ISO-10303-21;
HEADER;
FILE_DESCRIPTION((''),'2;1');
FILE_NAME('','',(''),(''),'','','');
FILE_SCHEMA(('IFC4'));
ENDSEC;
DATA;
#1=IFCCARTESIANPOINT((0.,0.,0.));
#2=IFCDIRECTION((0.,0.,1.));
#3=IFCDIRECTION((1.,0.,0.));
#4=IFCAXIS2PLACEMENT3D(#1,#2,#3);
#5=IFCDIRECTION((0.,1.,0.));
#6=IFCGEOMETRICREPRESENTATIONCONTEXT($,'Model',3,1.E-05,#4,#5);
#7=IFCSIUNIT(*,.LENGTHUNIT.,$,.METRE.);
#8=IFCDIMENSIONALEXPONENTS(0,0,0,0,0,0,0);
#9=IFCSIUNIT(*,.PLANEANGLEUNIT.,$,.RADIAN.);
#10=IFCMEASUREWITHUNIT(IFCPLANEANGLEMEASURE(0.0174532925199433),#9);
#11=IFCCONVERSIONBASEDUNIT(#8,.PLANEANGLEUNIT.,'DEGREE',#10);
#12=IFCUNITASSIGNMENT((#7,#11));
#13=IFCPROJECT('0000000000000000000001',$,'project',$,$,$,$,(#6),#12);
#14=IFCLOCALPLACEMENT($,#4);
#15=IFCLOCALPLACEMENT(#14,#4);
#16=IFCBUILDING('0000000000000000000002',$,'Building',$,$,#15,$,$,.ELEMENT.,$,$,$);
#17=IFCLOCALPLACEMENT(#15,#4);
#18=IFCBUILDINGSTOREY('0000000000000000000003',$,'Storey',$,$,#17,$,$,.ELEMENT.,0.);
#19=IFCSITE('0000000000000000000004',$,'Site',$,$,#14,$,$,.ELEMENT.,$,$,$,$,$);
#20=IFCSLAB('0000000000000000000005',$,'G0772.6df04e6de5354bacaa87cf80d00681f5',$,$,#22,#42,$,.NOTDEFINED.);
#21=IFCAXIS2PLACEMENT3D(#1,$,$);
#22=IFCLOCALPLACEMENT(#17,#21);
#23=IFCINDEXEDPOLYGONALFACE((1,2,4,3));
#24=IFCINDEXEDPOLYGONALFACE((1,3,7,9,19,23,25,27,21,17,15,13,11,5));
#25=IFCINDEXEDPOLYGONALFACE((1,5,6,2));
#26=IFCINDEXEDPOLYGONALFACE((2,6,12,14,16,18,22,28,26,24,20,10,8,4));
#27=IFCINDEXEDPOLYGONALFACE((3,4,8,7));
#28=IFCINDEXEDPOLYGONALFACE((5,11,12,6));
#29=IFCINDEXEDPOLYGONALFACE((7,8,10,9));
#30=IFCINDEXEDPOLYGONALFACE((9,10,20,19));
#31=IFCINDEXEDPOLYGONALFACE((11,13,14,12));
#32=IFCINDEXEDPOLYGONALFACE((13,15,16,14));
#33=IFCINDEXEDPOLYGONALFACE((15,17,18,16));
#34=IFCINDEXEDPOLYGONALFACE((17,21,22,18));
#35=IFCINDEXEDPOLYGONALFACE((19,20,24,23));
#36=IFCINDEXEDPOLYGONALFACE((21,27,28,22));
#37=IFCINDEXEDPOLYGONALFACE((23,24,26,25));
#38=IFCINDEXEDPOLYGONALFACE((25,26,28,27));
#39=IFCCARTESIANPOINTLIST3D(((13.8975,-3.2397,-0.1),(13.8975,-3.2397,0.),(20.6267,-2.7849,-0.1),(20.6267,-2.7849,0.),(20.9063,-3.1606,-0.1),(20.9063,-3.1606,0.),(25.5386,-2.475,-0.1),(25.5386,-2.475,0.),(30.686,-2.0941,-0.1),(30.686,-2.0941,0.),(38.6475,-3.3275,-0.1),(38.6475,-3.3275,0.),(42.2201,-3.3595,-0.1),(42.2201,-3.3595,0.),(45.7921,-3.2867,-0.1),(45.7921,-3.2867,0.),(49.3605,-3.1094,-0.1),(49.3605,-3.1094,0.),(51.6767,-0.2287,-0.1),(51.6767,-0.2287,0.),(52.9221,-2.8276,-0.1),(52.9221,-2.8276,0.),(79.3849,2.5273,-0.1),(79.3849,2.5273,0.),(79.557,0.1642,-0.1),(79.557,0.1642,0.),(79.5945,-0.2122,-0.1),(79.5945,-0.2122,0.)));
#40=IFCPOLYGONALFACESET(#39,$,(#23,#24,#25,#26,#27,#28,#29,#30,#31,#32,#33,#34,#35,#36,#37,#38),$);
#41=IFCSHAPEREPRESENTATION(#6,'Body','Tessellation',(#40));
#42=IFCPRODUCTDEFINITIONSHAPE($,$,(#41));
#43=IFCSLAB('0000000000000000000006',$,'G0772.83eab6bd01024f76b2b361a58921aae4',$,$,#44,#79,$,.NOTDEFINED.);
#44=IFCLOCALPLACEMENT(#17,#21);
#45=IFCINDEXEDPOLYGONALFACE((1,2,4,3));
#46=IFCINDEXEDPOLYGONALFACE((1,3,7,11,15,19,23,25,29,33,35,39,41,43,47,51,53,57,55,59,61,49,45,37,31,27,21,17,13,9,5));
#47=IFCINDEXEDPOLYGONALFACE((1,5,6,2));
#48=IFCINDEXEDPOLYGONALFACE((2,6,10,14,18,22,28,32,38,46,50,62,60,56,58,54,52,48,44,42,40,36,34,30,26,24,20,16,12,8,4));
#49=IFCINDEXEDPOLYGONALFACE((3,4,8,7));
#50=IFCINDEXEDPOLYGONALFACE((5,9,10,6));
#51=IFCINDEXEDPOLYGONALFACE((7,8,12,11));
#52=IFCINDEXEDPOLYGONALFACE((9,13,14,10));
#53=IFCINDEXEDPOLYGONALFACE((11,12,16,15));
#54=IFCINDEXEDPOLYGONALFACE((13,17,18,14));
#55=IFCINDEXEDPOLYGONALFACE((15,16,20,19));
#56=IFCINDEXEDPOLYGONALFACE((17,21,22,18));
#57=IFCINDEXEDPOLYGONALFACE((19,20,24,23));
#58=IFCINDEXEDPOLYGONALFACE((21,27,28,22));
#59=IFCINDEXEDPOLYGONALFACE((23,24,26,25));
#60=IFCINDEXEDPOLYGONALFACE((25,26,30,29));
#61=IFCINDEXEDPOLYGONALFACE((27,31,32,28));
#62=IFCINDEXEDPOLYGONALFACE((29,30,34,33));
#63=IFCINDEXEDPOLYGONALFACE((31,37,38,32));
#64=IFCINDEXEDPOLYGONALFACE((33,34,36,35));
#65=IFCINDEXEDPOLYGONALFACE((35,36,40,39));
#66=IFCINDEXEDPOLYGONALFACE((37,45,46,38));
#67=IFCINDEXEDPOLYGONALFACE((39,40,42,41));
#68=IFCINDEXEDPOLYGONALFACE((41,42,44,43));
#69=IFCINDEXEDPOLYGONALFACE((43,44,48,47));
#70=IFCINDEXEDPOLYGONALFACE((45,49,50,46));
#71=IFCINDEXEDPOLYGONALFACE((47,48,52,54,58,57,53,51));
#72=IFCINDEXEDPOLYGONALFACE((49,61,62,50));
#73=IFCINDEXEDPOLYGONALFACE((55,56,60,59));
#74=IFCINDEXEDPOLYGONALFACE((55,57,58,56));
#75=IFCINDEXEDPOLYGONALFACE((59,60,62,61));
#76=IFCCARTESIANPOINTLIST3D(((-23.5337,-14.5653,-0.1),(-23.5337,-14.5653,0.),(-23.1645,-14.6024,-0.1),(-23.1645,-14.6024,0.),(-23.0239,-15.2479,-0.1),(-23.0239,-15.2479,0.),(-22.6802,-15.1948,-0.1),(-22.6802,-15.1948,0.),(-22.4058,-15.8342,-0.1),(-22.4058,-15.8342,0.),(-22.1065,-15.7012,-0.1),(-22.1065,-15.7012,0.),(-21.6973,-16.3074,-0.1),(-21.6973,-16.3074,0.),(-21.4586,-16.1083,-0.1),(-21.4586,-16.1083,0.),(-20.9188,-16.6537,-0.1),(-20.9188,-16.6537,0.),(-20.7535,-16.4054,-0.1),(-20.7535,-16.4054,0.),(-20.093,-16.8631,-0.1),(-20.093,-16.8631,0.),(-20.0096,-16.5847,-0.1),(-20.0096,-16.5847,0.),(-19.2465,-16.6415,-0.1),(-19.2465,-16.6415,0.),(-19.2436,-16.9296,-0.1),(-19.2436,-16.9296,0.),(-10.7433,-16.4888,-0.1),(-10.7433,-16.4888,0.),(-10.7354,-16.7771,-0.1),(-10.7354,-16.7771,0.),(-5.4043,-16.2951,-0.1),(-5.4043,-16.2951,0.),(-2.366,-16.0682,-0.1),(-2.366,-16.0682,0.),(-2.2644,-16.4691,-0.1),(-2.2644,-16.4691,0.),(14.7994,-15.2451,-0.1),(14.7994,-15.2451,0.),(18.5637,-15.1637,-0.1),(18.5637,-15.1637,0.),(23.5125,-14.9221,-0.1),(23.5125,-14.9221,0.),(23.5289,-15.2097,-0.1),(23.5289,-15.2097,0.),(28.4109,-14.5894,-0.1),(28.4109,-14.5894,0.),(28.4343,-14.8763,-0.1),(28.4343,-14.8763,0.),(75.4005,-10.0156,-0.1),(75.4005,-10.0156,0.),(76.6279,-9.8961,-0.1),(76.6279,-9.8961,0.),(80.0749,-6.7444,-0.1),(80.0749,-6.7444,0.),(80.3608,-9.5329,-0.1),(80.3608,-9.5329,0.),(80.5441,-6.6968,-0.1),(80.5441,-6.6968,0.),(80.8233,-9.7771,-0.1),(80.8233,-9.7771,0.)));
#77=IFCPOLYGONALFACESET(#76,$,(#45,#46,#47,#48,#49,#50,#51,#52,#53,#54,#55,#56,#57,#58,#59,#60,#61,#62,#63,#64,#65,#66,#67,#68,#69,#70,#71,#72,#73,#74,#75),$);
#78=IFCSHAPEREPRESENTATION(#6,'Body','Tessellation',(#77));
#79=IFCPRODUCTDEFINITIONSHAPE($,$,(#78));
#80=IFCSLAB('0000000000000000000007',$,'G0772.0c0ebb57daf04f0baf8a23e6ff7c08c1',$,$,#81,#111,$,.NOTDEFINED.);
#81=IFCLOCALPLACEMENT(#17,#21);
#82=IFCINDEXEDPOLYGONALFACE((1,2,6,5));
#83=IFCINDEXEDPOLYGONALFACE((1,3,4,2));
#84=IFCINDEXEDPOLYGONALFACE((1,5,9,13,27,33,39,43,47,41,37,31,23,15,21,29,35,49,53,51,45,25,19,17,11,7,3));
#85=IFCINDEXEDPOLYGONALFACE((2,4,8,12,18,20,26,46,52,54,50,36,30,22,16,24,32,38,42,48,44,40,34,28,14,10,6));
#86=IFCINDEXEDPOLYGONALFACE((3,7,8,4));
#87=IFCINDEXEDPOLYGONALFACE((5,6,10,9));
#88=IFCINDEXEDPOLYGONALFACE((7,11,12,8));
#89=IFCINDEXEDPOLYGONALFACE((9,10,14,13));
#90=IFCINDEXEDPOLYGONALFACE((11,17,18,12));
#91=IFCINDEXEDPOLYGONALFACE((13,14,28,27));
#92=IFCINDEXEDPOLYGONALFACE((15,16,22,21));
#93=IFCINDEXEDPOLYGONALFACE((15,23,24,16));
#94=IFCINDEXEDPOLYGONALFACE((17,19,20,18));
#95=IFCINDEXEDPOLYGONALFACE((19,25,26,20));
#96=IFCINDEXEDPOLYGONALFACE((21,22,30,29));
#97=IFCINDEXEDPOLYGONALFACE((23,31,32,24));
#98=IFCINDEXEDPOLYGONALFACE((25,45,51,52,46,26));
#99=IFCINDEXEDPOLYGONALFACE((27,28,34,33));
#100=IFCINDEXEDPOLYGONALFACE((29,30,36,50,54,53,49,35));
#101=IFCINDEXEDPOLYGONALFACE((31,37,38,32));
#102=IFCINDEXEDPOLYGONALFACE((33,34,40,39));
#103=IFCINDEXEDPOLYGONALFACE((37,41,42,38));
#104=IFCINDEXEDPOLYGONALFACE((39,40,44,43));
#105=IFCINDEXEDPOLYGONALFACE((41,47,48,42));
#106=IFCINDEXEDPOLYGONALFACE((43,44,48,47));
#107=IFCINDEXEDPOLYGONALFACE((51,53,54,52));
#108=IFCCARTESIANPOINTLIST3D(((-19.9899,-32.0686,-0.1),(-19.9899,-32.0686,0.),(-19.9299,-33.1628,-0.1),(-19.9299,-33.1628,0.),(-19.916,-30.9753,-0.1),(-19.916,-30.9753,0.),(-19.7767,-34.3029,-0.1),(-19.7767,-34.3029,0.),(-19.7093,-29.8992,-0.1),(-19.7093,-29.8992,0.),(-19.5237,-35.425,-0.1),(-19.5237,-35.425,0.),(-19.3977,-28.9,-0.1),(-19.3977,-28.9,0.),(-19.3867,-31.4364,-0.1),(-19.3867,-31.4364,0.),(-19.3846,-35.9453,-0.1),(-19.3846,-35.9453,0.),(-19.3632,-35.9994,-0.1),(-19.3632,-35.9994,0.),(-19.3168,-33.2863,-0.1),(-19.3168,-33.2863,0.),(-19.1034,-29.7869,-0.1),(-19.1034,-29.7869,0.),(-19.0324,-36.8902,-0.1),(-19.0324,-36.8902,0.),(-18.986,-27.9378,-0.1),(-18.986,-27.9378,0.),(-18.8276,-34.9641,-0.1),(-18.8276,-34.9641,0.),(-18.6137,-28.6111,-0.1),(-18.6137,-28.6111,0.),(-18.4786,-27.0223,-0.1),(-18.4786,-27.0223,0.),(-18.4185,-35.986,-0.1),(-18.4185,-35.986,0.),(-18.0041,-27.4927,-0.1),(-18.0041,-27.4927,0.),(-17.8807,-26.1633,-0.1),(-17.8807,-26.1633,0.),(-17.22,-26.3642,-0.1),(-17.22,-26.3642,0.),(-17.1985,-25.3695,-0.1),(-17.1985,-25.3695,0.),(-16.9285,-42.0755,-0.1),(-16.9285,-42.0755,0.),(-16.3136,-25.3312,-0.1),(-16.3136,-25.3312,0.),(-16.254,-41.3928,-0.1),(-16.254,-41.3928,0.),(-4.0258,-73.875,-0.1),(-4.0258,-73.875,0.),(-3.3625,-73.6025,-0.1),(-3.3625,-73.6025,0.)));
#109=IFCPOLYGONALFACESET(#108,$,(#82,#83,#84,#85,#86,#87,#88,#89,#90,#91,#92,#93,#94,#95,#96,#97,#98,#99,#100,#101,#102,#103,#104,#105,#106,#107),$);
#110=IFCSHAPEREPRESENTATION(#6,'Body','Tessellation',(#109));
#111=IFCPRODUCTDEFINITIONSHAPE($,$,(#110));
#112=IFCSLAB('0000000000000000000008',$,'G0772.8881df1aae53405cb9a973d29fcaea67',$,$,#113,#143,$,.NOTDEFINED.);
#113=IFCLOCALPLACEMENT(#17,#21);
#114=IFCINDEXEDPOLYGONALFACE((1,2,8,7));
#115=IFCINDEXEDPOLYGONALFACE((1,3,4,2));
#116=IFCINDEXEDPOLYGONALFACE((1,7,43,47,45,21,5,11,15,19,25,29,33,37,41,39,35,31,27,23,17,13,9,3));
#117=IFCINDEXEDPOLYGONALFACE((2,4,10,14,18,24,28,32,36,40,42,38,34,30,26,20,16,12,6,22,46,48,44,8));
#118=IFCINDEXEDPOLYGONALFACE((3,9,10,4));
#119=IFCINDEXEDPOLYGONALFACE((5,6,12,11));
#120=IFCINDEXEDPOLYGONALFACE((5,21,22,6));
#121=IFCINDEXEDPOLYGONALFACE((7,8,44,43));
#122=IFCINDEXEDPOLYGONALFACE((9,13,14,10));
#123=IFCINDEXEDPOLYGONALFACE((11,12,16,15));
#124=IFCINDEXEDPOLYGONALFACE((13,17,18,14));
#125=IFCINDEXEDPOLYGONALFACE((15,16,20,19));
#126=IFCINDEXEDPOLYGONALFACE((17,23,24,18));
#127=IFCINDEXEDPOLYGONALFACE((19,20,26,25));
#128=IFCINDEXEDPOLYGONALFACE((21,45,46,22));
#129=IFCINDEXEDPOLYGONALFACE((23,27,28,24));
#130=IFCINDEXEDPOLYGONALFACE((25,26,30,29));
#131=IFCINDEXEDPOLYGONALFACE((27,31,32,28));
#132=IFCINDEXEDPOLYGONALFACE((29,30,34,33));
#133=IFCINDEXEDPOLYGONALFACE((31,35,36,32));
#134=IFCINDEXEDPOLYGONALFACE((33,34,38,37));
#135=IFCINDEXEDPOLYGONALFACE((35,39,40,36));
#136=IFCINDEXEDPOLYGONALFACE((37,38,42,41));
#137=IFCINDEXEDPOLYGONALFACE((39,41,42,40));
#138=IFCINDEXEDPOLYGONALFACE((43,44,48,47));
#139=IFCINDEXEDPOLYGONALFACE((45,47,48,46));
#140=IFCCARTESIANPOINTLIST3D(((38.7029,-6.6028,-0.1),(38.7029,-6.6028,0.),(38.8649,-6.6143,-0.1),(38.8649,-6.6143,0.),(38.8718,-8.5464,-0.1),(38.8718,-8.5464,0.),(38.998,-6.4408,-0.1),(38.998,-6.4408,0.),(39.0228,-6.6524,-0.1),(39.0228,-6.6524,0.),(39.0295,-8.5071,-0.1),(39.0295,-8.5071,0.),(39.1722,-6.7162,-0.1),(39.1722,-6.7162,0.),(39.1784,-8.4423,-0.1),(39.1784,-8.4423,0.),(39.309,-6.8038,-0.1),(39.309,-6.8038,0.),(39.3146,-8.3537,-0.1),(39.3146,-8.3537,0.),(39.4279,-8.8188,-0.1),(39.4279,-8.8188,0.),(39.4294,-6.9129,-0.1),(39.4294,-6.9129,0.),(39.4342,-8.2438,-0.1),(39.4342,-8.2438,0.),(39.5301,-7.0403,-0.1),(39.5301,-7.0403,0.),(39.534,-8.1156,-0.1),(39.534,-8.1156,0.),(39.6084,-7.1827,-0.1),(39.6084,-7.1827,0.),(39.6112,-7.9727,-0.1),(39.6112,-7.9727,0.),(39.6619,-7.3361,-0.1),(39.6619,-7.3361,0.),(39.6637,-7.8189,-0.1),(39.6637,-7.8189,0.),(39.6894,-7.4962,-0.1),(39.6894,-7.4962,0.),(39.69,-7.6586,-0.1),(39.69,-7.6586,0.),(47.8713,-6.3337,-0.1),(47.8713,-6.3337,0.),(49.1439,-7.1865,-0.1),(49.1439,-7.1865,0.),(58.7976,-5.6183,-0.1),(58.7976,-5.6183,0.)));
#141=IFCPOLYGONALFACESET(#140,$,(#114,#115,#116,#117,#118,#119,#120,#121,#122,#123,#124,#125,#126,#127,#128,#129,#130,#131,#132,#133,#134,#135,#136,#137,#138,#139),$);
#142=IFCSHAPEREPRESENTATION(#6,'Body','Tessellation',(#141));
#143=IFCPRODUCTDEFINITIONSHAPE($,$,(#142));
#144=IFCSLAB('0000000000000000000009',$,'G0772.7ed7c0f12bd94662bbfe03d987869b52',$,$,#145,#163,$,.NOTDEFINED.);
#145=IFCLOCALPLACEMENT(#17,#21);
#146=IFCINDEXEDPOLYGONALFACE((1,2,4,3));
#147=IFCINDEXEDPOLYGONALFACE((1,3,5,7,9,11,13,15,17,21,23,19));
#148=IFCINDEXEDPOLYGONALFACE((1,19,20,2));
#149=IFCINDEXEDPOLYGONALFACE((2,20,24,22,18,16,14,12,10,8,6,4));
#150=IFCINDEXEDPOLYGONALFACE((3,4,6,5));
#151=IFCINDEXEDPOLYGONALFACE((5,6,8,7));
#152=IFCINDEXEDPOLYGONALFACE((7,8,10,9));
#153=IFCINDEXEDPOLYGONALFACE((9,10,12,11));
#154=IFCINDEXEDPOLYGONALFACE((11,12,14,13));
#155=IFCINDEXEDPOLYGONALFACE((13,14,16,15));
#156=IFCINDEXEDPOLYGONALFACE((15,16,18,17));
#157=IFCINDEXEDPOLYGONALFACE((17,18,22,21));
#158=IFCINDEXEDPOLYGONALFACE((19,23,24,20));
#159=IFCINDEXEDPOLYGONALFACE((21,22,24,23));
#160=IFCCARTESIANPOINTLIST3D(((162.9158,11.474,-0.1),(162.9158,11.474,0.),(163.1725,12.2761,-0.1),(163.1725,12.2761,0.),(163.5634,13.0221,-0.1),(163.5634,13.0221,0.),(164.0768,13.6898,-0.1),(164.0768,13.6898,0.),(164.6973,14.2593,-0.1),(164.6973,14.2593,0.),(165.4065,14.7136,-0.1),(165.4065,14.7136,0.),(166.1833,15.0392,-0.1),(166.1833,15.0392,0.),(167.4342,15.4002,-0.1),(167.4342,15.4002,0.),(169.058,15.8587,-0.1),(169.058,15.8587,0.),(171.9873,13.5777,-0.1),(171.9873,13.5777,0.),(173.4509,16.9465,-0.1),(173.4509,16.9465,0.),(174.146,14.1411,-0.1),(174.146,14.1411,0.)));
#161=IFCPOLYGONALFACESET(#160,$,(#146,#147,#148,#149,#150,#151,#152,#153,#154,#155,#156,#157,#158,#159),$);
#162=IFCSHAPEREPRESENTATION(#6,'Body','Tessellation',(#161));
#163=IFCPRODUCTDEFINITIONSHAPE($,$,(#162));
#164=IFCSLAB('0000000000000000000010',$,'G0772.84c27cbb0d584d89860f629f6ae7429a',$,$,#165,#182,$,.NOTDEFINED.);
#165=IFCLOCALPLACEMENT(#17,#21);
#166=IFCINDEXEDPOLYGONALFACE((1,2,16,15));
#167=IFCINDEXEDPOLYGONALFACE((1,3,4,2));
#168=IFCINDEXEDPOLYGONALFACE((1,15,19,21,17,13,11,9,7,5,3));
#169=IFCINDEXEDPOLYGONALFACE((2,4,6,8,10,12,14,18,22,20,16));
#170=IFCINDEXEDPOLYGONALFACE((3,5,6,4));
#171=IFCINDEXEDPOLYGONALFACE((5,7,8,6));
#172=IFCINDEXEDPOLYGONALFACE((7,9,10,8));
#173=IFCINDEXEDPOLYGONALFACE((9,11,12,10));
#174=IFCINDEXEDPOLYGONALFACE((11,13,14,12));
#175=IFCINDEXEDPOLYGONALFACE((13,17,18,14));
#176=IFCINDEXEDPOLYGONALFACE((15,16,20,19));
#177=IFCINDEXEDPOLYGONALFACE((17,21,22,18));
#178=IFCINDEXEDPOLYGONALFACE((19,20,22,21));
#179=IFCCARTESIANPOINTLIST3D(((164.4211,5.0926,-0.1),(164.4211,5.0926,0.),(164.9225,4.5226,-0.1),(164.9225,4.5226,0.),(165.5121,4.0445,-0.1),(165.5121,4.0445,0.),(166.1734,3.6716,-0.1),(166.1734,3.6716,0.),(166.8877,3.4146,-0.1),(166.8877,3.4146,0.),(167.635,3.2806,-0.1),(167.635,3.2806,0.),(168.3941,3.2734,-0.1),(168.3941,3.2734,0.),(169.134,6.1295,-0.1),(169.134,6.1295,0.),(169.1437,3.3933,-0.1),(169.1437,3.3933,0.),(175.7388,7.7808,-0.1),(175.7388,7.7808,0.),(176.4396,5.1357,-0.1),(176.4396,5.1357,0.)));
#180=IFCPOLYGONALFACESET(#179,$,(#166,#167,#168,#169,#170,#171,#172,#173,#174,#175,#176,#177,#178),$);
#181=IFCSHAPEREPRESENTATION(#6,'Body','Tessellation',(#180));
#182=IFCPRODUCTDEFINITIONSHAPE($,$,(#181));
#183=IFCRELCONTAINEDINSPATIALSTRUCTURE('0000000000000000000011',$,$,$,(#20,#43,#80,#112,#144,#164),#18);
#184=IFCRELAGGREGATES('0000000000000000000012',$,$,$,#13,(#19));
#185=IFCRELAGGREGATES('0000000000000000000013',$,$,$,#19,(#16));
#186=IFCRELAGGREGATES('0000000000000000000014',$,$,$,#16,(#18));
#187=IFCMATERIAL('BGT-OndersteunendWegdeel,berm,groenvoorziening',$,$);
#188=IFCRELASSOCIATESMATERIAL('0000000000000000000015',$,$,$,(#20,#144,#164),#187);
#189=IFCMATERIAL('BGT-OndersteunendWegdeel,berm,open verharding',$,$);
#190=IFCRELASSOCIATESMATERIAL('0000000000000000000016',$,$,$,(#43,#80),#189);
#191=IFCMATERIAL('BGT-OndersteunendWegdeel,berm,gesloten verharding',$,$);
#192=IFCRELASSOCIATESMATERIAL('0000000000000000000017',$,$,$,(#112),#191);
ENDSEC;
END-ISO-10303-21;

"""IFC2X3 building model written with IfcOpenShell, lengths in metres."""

from ifc_helpers import new_model, entity, si_unit, converted_unit, direction, frame, origin_with_axes, place, context, project, spatial, polyline, outline, extrude, material, element, save


model = new_model("IFC2X3")

# Units and contexts
model_context = context("Model", 3, precision=1e-05, world=origin_with_axes(), true_north=direction((0.0, 1.0, 0.0)))
ifc_project = project(units=[si_unit("LENGTHUNIT", "METRE"), converted_unit("PLANEANGLEUNIT", "DEGREE", entity("IfcPlaneAngleMeasure", 0.0174532925199433), si_unit("PLANEANGLEUNIT", "RADIAN"), dimensions=[0, 0, 0, 0, 0, 0, 0])], contexts=[model_context])

# Site, building, storey
site_placement = place(None, origin_with_axes())
site = spatial("IfcSite", under=ifc_project, at=site_placement, Name="Site", CompositionType="ELEMENT")
building_placement = place(site_placement, origin_with_axes())
building = spatial("IfcBuilding", under=site, at=building_placement, Name="Building", CompositionType="ELEMENT")
storey_placement = place(building_placement, origin_with_axes())
storey = spatial("IfcBuildingStorey", under=building, at=storey_placement, Name="Storey", CompositionType="ELEMENT", Elevation=0.0)

# Slabs
ifc_material_1 = material(Name="BGT-OndersteunendWegdeel,berm,open verharding")
ifc_material_2 = material(Name="BGT-OndersteunendWegdeel,berm,groenvoorziening")
slab_1_placement = place(storey_placement, frame((0.0, 0.0, -0.1), z_axis=(0.0, 0.0, 1.0), x_axis=(1.0, 0.0, 0.0)))
element("IfcSlab", 1, at=slab_1_placement, inside=storey, material=ifc_material_2, Name="G0772.6df04e6de5354bacaa87cf80d00681f5", PredefinedType="NOTDEFINED", context=model_context, shape_type="SweptSolid", body=[
    extrude(outline(polyline([(20.6267, -2.7849), (25.5386, -2.475), (30.686, -2.0941), (51.6767, -0.2287), (79.3849, 2.5273), (79.557, 0.1642), (79.5945, -0.2122), (52.9221, -2.8276), (49.3605, -3.1094), (45.7921, -3.2867), (42.2201, -3.3595), (38.6475, -3.3275), (20.9063, -3.1606), (13.8975, -3.2397), (20.6267, -2.7849)])), origin_with_axes(), (0.0, 0.0, 1.0), 0.1),
])
slab_2_placement = place(storey_placement, frame((0.0, 0.0, -0.1), z_axis=(0.0, 0.0, 1.0), x_axis=(1.0, 0.0, 0.0)))
element("IfcSlab", 2, at=slab_2_placement, inside=storey, material=ifc_material_1, Name="G0772.83eab6bd01024f76b2b361a58921aae4", PredefinedType="NOTDEFINED", context=model_context, shape_type="SweptSolid", body=[
    extrude(outline(polyline([(18.5637, -15.1637), (23.5125, -14.9221), (28.4109, -14.5894), (75.4005, -10.0156), (76.6279, -9.8961), (80.3608, -9.5329), (80.0749, -6.7444), (80.5441, -6.6968), (80.8233, -9.7771), (28.4343, -14.8763), (23.5289, -15.2097), (-2.2644, -16.4691), (-10.7354, -16.7771), (-19.2436, -16.9296), (-20.093, -16.8631), (-20.9188, -16.6537), (-21.6973, -16.3074), (-22.4058, -15.8342), (-23.0239, -15.2479), (-23.5337, -14.5653), (-23.1645, -14.6024), (-22.6802, -15.1948), (-22.1065, -15.7012), (-21.4586, -16.1083), (-20.7535, -16.4054), (-20.0096, -16.5847), (-19.2465, -16.6415), (-10.7433, -16.4888), (-5.4043, -16.2951), (-2.366, -16.0682), (14.7994, -15.2451), (18.5637, -15.1637)])), origin_with_axes(), (0.0, 0.0, 1.0), 0.1),
])
slab_3_placement = place(storey_placement, frame((0.0, 0.0, -0.1), z_axis=(0.0, 0.0, 1.0), x_axis=(1.0, 0.0, 0.0)))
element("IfcSlab", 3, at=slab_3_placement, inside=storey, material=ifc_material_1, Name="G0772.0c0ebb57daf04f0baf8a23e6ff7c08c1", PredefinedType="NOTDEFINED", context=model_context, shape_type="SweptSolid", body=[
    extrude(outline(polyline([(-16.254, -41.3928), (-3.3625, -73.6025), (-4.0258, -73.875), (-16.9285, -42.0755), (-19.0324, -36.8902), (-19.3632, -35.9994), (-19.3846, -35.9453), (-19.5237, -35.425), (-19.7767, -34.3029), (-19.9299, -33.1628), (-19.9899, -32.0686), (-19.916, -30.9753), (-19.7093, -29.8992), (-19.3977, -28.9), (-18.986, -27.9378), (-18.4786, -27.0223), (-17.8807, -26.1633), (-17.1985, -25.3695), (-16.3136, -25.3312), (-17.22, -26.3642), (-18.0041, -27.4927), (-18.6137, -28.6111), (-19.1034, -29.7869), (-19.3867, -31.4364), (-19.3168, -33.2863), (-18.8276, -34.9641), (-18.4185, -35.986), (-16.254, -41.3928)])), origin_with_axes(), (0.0, 0.0, 1.0), 0.1),
])
ifc_material_3 = material(Name="BGT-OndersteunendWegdeel,berm,gesloten verharding")
slab_4_placement = place(storey_placement, frame((0.0, 0.0, -0.1), z_axis=(0.0, 0.0, 1.0), x_axis=(1.0, 0.0, 0.0)))
element("IfcSlab", 4, at=slab_4_placement, inside=storey, material=ifc_material_3, Name="G0772.8881df1aae53405cb9a973d29fcaea67", PredefinedType="NOTDEFINED", context=model_context, shape_type="SweptSolid", body=[
    extrude(outline(polyline([(38.998, -6.4408), (47.8713, -6.3337), (58.7976, -5.6183), (49.1439, -7.1865), (39.4279, -8.8188), (38.8718, -8.5464), (39.0295, -8.5071), (39.1784, -8.4423), (39.3146, -8.3537), (39.4342, -8.2438), (39.534, -8.1156), (39.6112, -7.9727), (39.6637, -7.8189), (39.69, -7.6586), (39.6894, -7.4962), (39.6619, -7.3361), (39.6084, -7.1827), (39.5301, -7.0403), (39.4294, -6.9129), (39.309, -6.8038), (39.1722, -6.7162), (39.0228, -6.6524), (38.8649, -6.6143), (38.7029, -6.6028), (38.998, -6.4408)])), origin_with_axes(), (0.0, 0.0, 1.0), 0.1),
])
slab_5_placement = place(storey_placement, frame((0.0, 0.0, -0.1), z_axis=(0.0, 0.0, 1.0), x_axis=(1.0, 0.0, 0.0)))
element("IfcSlab", 5, at=slab_5_placement, inside=storey, material=ifc_material_2, Name="G0772.7ed7c0f12bd94662bbfe03d987869b52", PredefinedType="NOTDEFINED", context=model_context, shape_type="SweptSolid", body=[
    extrude(outline(polyline([(163.1725, 12.2761), (163.5634, 13.0221), (164.0768, 13.6898), (164.6973, 14.2593), (165.4065, 14.7136), (166.1833, 15.0392), (167.4342, 15.4002), (169.058, 15.8587), (173.4509, 16.9465), (174.146, 14.1411), (171.9873, 13.5777), (162.9158, 11.474), (163.1725, 12.2761)])), origin_with_axes(), (0.0, 0.0, 1.0), 0.1),
])
slab_6_placement = place(storey_placement, frame((0.0, 0.0, -0.1), z_axis=(0.0, 0.0, 1.0), x_axis=(1.0, 0.0, 0.0)))
element("IfcSlab", 6, at=slab_6_placement, inside=storey, material=ifc_material_2, Name="G0772.84c27cbb0d584d89860f629f6ae7429a", PredefinedType="NOTDEFINED", context=model_context, shape_type="SweptSolid", body=[
    extrude(outline(polyline([(175.7388, 7.7808), (176.4396, 5.1357), (169.1437, 3.3933), (168.3941, 3.2734), (167.635, 3.2806), (166.8877, 3.4146), (166.1734, 3.6716), (165.5121, 4.0445), (164.9225, 4.5226), (164.4211, 5.0926), (169.134, 6.1295), (175.7388, 7.7808)])), origin_with_axes(), (0.0, 0.0, 1.0), 0.1),
])

save(model, "model.ifc")
